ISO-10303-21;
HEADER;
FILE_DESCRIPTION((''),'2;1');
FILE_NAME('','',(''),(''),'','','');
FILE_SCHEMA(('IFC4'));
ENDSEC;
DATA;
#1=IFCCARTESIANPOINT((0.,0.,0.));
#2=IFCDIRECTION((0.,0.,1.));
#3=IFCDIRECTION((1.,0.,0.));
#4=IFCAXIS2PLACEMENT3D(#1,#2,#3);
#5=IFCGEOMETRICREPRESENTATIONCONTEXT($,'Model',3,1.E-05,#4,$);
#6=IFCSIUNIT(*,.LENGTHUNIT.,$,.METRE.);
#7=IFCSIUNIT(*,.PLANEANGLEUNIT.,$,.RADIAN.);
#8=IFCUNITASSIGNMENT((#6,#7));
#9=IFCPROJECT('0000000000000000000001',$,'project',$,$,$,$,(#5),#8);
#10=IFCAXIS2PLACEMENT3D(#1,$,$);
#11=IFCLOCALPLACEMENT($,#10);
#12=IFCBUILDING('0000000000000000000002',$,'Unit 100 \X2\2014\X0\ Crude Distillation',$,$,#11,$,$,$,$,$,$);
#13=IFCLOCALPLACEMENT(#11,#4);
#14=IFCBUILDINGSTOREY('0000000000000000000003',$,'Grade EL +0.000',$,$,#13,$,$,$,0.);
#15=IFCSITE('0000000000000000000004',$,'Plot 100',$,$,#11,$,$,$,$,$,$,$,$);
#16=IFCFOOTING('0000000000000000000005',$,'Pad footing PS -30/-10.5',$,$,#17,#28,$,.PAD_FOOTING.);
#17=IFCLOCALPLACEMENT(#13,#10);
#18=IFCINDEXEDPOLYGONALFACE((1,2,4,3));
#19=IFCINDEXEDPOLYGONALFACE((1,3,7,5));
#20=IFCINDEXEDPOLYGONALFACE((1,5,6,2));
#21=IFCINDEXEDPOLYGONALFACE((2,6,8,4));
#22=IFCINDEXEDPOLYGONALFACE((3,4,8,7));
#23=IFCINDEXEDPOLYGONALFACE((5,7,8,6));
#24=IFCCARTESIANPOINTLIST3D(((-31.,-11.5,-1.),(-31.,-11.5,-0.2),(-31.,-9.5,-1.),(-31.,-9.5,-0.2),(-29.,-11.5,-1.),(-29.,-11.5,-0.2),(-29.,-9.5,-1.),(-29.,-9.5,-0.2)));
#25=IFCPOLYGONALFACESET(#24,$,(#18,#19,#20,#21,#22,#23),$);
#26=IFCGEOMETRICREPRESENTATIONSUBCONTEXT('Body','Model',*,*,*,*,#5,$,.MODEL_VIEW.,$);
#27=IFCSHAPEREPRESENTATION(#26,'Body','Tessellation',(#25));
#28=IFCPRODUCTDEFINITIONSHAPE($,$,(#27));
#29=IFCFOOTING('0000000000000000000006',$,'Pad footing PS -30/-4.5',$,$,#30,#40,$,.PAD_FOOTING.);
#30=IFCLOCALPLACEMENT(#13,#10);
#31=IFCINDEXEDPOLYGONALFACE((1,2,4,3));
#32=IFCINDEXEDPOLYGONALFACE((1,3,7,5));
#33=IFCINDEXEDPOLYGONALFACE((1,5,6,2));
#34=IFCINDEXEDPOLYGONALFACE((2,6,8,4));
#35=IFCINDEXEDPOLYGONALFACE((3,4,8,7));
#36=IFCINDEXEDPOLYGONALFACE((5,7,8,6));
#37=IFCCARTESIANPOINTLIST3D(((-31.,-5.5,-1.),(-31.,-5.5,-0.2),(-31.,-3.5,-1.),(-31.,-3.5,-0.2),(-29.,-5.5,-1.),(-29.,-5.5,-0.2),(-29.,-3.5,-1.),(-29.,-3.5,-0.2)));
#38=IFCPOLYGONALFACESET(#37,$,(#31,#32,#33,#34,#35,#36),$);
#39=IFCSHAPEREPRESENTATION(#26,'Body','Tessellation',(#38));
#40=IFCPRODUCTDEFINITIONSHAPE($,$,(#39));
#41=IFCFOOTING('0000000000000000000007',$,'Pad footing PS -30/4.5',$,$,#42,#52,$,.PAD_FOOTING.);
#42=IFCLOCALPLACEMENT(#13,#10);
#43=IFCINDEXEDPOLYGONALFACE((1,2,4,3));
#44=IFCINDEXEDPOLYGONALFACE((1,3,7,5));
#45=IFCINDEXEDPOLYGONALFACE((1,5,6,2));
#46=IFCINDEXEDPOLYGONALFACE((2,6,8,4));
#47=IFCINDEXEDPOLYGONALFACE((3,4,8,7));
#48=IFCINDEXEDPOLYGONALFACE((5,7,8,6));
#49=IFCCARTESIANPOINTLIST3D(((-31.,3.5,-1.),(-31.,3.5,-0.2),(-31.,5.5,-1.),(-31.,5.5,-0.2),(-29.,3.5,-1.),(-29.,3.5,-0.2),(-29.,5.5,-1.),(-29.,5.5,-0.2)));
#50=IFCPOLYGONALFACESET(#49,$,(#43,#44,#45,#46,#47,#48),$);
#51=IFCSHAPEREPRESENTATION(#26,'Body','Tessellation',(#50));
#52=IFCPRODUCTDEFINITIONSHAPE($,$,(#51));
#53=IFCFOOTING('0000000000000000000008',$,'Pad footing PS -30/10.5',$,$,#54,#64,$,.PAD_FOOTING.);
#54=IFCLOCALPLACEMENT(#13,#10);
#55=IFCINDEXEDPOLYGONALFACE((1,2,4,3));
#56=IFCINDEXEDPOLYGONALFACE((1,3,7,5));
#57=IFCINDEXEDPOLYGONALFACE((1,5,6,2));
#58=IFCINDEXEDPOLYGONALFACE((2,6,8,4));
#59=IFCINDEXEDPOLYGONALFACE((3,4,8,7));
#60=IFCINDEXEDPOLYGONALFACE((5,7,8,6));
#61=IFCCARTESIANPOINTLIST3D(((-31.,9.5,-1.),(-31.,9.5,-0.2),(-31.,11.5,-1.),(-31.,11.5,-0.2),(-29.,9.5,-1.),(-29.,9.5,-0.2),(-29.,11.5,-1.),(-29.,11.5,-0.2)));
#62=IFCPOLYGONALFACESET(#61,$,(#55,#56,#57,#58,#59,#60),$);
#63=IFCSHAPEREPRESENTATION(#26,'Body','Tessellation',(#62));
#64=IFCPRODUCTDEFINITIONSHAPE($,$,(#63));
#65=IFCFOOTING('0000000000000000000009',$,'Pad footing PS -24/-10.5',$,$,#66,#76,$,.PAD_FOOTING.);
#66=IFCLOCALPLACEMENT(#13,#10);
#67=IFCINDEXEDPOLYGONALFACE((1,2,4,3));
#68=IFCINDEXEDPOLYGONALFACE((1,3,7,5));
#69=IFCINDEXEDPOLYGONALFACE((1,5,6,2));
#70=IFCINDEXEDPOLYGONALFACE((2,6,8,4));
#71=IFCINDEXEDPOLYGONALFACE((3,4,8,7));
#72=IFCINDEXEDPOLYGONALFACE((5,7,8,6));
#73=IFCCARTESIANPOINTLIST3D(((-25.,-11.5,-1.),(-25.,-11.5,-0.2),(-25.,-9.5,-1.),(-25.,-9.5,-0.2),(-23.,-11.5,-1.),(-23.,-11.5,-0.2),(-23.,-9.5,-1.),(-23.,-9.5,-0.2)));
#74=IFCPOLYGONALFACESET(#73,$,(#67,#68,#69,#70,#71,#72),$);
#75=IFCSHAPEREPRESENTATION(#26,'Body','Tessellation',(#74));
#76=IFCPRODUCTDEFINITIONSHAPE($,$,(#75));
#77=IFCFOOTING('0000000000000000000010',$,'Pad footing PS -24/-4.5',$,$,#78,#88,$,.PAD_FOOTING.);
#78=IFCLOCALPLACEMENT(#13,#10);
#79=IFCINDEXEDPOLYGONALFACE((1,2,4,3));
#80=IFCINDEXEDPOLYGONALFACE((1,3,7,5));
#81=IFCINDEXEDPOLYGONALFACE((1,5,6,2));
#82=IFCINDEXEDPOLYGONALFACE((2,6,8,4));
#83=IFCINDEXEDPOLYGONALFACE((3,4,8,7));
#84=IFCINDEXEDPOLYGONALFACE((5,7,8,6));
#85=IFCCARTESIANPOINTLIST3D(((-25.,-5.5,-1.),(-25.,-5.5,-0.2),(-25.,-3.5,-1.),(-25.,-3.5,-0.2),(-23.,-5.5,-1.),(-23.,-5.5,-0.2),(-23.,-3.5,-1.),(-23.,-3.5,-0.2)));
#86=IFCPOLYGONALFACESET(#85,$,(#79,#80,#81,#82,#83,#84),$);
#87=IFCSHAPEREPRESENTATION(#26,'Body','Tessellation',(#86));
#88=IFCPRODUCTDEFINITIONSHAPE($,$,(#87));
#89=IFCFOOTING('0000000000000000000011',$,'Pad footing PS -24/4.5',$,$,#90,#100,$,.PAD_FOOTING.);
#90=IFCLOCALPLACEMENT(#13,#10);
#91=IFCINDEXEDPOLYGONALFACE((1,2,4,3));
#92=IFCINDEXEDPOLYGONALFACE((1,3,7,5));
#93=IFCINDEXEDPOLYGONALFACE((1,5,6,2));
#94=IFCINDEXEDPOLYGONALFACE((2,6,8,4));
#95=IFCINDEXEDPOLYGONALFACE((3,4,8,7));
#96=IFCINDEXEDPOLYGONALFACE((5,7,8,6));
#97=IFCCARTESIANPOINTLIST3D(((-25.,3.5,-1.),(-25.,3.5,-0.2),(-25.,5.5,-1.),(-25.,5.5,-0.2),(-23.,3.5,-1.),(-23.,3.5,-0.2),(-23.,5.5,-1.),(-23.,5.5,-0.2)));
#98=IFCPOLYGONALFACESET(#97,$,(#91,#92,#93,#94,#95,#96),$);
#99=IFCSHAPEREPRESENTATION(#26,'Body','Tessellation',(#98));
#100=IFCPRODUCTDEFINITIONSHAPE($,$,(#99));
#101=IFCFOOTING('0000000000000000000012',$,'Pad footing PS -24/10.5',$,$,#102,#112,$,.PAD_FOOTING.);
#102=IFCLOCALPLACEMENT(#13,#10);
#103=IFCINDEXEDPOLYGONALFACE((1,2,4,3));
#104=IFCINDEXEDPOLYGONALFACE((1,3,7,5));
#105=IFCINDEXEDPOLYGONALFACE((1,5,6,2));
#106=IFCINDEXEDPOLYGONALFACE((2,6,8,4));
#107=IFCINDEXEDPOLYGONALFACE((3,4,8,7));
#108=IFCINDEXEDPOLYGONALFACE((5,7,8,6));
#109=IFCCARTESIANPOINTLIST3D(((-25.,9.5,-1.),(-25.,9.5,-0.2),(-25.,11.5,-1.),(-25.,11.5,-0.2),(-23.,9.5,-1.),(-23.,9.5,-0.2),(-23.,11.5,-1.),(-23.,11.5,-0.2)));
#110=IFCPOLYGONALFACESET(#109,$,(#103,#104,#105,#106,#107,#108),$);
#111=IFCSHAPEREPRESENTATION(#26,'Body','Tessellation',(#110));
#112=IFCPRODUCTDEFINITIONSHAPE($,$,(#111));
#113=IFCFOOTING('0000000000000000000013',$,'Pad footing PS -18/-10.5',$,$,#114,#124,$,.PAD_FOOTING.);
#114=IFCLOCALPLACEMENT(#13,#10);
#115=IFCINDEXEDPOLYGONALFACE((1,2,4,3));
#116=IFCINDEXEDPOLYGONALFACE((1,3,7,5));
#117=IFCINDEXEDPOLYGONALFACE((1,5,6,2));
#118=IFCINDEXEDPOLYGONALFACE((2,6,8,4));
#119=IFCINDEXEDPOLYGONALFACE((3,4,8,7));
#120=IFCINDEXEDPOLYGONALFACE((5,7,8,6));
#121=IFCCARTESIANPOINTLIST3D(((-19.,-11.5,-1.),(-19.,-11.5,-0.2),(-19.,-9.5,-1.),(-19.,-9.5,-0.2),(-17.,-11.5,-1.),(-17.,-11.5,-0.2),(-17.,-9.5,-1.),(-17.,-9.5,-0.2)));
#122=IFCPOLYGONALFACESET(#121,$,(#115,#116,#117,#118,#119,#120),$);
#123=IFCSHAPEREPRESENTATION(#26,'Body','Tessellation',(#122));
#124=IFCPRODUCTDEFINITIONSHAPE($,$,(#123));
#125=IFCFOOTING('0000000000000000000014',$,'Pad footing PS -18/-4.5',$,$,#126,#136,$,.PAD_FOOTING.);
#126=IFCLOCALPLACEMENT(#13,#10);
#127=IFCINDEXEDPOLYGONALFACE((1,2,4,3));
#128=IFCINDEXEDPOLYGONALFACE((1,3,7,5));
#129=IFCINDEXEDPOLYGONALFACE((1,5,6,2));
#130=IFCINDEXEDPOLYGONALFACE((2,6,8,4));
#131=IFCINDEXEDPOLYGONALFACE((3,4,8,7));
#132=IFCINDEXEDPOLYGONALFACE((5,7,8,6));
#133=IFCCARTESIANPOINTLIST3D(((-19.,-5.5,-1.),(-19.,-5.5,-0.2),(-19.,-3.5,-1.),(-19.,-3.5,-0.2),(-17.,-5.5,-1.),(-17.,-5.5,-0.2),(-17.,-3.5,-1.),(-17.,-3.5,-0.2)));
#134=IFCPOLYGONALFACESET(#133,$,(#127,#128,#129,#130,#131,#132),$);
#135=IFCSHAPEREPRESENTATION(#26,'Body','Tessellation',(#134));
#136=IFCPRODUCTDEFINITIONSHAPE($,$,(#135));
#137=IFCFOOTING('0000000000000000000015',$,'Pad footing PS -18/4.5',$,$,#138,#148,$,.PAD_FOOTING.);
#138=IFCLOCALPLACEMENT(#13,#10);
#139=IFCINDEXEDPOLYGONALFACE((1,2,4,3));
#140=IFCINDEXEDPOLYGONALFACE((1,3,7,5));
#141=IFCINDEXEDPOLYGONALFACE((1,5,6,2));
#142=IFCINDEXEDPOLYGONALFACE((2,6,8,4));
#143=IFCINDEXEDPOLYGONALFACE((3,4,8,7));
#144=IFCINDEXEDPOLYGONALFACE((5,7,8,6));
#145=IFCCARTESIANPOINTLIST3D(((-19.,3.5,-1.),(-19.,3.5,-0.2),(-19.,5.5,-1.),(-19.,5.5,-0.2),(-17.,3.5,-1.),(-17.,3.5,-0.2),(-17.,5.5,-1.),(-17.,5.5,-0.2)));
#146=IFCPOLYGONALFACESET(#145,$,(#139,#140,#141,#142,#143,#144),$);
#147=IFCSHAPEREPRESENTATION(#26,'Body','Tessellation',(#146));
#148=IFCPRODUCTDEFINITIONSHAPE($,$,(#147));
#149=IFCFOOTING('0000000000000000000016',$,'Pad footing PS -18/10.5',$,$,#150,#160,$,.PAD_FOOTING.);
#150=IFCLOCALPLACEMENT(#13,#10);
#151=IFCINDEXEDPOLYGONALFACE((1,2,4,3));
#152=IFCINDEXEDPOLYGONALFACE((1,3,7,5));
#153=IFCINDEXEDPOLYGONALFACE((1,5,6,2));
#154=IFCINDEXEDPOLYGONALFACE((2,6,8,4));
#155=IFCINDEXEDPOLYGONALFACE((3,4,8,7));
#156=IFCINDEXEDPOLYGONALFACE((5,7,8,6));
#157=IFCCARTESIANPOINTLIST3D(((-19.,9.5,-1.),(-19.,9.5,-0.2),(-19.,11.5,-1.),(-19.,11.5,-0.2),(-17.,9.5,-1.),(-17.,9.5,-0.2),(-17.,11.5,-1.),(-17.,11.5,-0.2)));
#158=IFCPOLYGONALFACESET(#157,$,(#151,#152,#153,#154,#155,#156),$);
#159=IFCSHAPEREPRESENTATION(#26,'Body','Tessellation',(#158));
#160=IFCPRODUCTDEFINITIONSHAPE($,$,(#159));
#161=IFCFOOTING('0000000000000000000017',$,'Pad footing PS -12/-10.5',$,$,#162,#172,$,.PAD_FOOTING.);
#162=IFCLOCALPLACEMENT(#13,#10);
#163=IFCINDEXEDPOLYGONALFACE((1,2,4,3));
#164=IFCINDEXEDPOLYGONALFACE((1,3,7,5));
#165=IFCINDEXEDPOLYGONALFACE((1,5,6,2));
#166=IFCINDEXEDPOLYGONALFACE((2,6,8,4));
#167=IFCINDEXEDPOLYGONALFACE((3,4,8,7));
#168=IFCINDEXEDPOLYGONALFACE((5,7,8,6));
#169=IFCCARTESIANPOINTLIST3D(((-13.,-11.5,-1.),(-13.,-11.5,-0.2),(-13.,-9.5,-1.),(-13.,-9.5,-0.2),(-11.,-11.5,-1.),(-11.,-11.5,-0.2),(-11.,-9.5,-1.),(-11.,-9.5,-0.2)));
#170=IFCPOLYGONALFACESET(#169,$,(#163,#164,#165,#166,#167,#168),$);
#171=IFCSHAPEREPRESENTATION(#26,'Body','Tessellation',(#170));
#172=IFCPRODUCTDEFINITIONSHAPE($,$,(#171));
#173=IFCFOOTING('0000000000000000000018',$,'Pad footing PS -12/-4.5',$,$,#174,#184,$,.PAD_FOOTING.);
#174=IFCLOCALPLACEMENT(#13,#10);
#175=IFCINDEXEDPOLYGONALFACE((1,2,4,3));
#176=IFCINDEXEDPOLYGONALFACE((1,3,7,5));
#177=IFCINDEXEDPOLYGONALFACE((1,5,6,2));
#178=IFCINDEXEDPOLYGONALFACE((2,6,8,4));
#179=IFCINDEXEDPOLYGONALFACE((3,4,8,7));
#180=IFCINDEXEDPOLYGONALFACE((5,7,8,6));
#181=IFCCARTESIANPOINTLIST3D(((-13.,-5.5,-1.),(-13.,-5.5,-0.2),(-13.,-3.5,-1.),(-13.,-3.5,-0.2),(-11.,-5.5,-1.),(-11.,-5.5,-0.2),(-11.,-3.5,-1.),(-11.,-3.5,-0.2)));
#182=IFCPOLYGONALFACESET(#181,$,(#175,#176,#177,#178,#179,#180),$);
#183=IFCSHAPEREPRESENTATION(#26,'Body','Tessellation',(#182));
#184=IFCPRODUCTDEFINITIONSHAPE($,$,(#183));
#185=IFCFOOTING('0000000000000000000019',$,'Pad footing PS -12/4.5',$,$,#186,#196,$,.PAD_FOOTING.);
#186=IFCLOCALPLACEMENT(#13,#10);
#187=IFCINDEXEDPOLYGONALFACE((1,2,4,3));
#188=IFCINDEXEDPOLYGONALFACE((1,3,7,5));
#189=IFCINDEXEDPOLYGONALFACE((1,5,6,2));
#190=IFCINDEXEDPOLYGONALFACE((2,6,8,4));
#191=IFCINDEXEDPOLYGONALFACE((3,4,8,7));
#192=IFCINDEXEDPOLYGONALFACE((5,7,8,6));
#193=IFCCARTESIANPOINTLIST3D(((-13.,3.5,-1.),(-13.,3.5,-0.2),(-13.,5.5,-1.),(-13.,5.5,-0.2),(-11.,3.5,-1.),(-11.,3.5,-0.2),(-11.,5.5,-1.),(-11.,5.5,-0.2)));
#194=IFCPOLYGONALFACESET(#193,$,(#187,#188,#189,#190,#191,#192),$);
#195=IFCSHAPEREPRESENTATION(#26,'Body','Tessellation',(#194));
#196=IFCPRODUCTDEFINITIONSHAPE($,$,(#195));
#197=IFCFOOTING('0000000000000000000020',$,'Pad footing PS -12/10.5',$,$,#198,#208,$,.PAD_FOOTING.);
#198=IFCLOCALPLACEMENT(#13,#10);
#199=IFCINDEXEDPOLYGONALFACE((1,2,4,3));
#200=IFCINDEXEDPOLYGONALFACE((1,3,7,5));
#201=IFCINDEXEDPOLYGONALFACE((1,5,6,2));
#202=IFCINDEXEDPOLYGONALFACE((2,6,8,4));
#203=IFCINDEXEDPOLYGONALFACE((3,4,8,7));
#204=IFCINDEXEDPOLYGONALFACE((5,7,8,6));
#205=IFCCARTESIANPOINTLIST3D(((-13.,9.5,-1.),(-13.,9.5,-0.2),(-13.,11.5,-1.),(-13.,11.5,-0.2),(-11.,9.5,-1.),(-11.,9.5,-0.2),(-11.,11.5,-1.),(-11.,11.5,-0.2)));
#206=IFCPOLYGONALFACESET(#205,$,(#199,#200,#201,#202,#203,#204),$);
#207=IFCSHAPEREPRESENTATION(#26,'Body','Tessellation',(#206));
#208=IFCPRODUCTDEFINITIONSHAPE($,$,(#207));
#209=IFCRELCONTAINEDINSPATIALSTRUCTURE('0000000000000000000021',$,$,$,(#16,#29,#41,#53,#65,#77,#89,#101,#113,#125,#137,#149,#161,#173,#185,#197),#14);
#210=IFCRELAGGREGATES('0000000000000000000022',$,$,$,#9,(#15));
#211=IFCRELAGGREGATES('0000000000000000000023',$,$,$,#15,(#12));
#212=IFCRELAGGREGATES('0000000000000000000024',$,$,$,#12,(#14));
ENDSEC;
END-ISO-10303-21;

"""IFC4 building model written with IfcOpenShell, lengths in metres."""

from ifc_helpers import new_model, si_unit, frame, origin, origin_with_axes, origin_2d, place, context, subcontext, project, spatial, rectangle, extrude, element, save


model = new_model("IFC4")

# Units and contexts
model_context = context("Model", 3, precision=1e-05, world=origin_with_axes())
body_context = subcontext(model_context, "Body", "Model", "MODEL_VIEW")
ifc_project = project(units=[si_unit("LENGTHUNIT", "METRE"), si_unit("PLANEANGLEUNIT", "RADIAN")], contexts=[model_context])

# Site, building, storey
placement = place(None, origin())
site = spatial("IfcSite", under=ifc_project, at=placement, Name="Plot 100")
building = spatial("IfcBuilding", under=site, at=placement, Name="Unit 100 — Crude Distillation")
storey_placement = place(placement, origin_with_axes())
storey = spatial("IfcBuildingStorey", under=building, at=storey_placement, Name="Grade EL +0.000", Elevation=0.0)

# Footings
footing_1_placement = place(storey_placement, origin_with_axes())
element("IfcFooting", 1, at=footing_1_placement, inside=storey, Name="Pad footing PS -30/-10.5", PredefinedType="PAD_FOOTING", context=body_context, shape_type="SweptSolid", body=[
    extrude(rectangle(XDim=2.0, YDim=2.0, at=origin_2d()), frame((-30.0, -10.5, -1.0), z_axis=(0.0, 0.0, 1.0), x_axis=(1.0, 0.0, 0.0)), (0.0, 0.0, 1.0), 0.8),
])
footing_2_placement = place(storey_placement, origin_with_axes())
element("IfcFooting", 2, at=footing_2_placement, inside=storey, Name="Pad footing PS -30/-4.5", PredefinedType="PAD_FOOTING", context=body_context, shape_type="SweptSolid", body=[
    extrude(rectangle(XDim=2.0, YDim=2.0, at=origin_2d()), frame((-30.0, -4.5, -1.0), z_axis=(0.0, 0.0, 1.0), x_axis=(1.0, 0.0, 0.0)), (0.0, 0.0, 1.0), 0.8),
])
footing_3_placement = place(storey_placement, origin_with_axes())
element("IfcFooting", 3, at=footing_3_placement, inside=storey, Name="Pad footing PS -30/4.5", PredefinedType="PAD_FOOTING", context=body_context, shape_type="SweptSolid", body=[
    extrude(rectangle(XDim=2.0, YDim=2.0, at=origin_2d()), frame((-30.0, 4.5, -1.0), z_axis=(0.0, 0.0, 1.0), x_axis=(1.0, 0.0, 0.0)), (0.0, 0.0, 1.0), 0.8),
])
footing_4_placement = place(storey_placement, origin_with_axes())
element("IfcFooting", 4, at=footing_4_placement, inside=storey, Name="Pad footing PS -30/10.5", PredefinedType="PAD_FOOTING", context=body_context, shape_type="SweptSolid", body=[
    extrude(rectangle(XDim=2.0, YDim=2.0, at=origin_2d()), frame((-30.0, 10.5, -1.0), z_axis=(0.0, 0.0, 1.0), x_axis=(1.0, 0.0, 0.0)), (0.0, 0.0, 1.0), 0.8),
])
footing_5_placement = place(storey_placement, origin_with_axes())
element("IfcFooting", 5, at=footing_5_placement, inside=storey, Name="Pad footing PS -24/-10.5", PredefinedType="PAD_FOOTING", context=body_context, shape_type="SweptSolid", body=[
    extrude(rectangle(XDim=2.0, YDim=2.0, at=origin_2d()), frame((-24.0, -10.5, -1.0), z_axis=(0.0, 0.0, 1.0), x_axis=(1.0, 0.0, 0.0)), (0.0, 0.0, 1.0), 0.8),
])
footing_6_placement = place(storey_placement, origin_with_axes())
element("IfcFooting", 6, at=footing_6_placement, inside=storey, Name="Pad footing PS -24/-4.5", PredefinedType="PAD_FOOTING", context=body_context, shape_type="SweptSolid", body=[
    extrude(rectangle(XDim=2.0, YDim=2.0, at=origin_2d()), frame((-24.0, -4.5, -1.0), z_axis=(0.0, 0.0, 1.0), x_axis=(1.0, 0.0, 0.0)), (0.0, 0.0, 1.0), 0.8),
])
footing_7_placement = place(storey_placement, origin_with_axes())
element("IfcFooting", 7, at=footing_7_placement, inside=storey, Name="Pad footing PS -24/4.5", PredefinedType="PAD_FOOTING", context=body_context, shape_type="SweptSolid", body=[
    extrude(rectangle(XDim=2.0, YDim=2.0, at=origin_2d()), frame((-24.0, 4.5, -1.0), z_axis=(0.0, 0.0, 1.0), x_axis=(1.0, 0.0, 0.0)), (0.0, 0.0, 1.0), 0.8),
])
footing_8_placement = place(storey_placement, origin_with_axes())
element("IfcFooting", 8, at=footing_8_placement, inside=storey, Name="Pad footing PS -24/10.5", PredefinedType="PAD_FOOTING", context=body_context, shape_type="SweptSolid", body=[
    extrude(rectangle(XDim=2.0, YDim=2.0, at=origin_2d()), frame((-24.0, 10.5, -1.0), z_axis=(0.0, 0.0, 1.0), x_axis=(1.0, 0.0, 0.0)), (0.0, 0.0, 1.0), 0.8),
])
footing_9_placement = place(storey_placement, origin_with_axes())
element("IfcFooting", 9, at=footing_9_placement, inside=storey, Name="Pad footing PS -18/-10.5", PredefinedType="PAD_FOOTING", context=body_context, shape_type="SweptSolid", body=[
    extrude(rectangle(XDim=2.0, YDim=2.0, at=origin_2d()), frame((-18.0, -10.5, -1.0), z_axis=(0.0, 0.0, 1.0), x_axis=(1.0, 0.0, 0.0)), (0.0, 0.0, 1.0), 0.8),
])
footing_10_placement = place(storey_placement, origin_with_axes())
element("IfcFooting", 10, at=footing_10_placement, inside=storey, Name="Pad footing PS -18/-4.5", PredefinedType="PAD_FOOTING", context=body_context, shape_type="SweptSolid", body=[
    extrude(rectangle(XDim=2.0, YDim=2.0, at=origin_2d()), frame((-18.0, -4.5, -1.0), z_axis=(0.0, 0.0, 1.0), x_axis=(1.0, 0.0, 0.0)), (0.0, 0.0, 1.0), 0.8),
])
footing_11_placement = place(storey_placement, origin_with_axes())
element("IfcFooting", 11, at=footing_11_placement, inside=storey, Name="Pad footing PS -18/4.5", PredefinedType="PAD_FOOTING", context=body_context, shape_type="SweptSolid", body=[
    extrude(rectangle(XDim=2.0, YDim=2.0, at=origin_2d()), frame((-18.0, 4.5, -1.0), z_axis=(0.0, 0.0, 1.0), x_axis=(1.0, 0.0, 0.0)), (0.0, 0.0, 1.0), 0.8),
])
footing_12_placement = place(storey_placement, origin_with_axes())
element("IfcFooting", 12, at=footing_12_placement, inside=storey, Name="Pad footing PS -18/10.5", PredefinedType="PAD_FOOTING", context=body_context, shape_type="SweptSolid", body=[
    extrude(rectangle(XDim=2.0, YDim=2.0, at=origin_2d()), frame((-18.0, 10.5, -1.0), z_axis=(0.0, 0.0, 1.0), x_axis=(1.0, 0.0, 0.0)), (0.0, 0.0, 1.0), 0.8),
])
footing_13_placement = place(storey_placement, origin_with_axes())
element("IfcFooting", 13, at=footing_13_placement, inside=storey, Name="Pad footing PS -12/-10.5", PredefinedType="PAD_FOOTING", context=body_context, shape_type="SweptSolid", body=[
    extrude(rectangle(XDim=2.0, YDim=2.0, at=origin_2d()), frame((-12.0, -10.5, -1.0), z_axis=(0.0, 0.0, 1.0), x_axis=(1.0, 0.0, 0.0)), (0.0, 0.0, 1.0), 0.8),
])
footing_14_placement = place(storey_placement, origin_with_axes())
element("IfcFooting", 14, at=footing_14_placement, inside=storey, Name="Pad footing PS -12/-4.5", PredefinedType="PAD_FOOTING", context=body_context, shape_type="SweptSolid", body=[
    extrude(rectangle(XDim=2.0, YDim=2.0, at=origin_2d()), frame((-12.0, -4.5, -1.0), z_axis=(0.0, 0.0, 1.0), x_axis=(1.0, 0.0, 0.0)), (0.0, 0.0, 1.0), 0.8),
])
footing_15_placement = place(storey_placement, origin_with_axes())
element("IfcFooting", 15, at=footing_15_placement, inside=storey, Name="Pad footing PS -12/4.5", PredefinedType="PAD_FOOTING", context=body_context, shape_type="SweptSolid", body=[
    extrude(rectangle(XDim=2.0, YDim=2.0, at=origin_2d()), frame((-12.0, 4.5, -1.0), z_axis=(0.0, 0.0, 1.0), x_axis=(1.0, 0.0, 0.0)), (0.0, 0.0, 1.0), 0.8),
])
footing_16_placement = place(storey_placement, origin_with_axes())
element("IfcFooting", 16, at=footing_16_placement, inside=storey, Name="Pad footing PS -12/10.5", PredefinedType="PAD_FOOTING", context=body_context, shape_type="SweptSolid", body=[
    extrude(rectangle(XDim=2.0, YDim=2.0, at=origin_2d()), frame((-12.0, 10.5, -1.0), z_axis=(0.0, 0.0, 1.0), x_axis=(1.0, 0.0, 0.0)), (0.0, 0.0, 1.0), 0.8),
])

save(model, "model.ifc")
